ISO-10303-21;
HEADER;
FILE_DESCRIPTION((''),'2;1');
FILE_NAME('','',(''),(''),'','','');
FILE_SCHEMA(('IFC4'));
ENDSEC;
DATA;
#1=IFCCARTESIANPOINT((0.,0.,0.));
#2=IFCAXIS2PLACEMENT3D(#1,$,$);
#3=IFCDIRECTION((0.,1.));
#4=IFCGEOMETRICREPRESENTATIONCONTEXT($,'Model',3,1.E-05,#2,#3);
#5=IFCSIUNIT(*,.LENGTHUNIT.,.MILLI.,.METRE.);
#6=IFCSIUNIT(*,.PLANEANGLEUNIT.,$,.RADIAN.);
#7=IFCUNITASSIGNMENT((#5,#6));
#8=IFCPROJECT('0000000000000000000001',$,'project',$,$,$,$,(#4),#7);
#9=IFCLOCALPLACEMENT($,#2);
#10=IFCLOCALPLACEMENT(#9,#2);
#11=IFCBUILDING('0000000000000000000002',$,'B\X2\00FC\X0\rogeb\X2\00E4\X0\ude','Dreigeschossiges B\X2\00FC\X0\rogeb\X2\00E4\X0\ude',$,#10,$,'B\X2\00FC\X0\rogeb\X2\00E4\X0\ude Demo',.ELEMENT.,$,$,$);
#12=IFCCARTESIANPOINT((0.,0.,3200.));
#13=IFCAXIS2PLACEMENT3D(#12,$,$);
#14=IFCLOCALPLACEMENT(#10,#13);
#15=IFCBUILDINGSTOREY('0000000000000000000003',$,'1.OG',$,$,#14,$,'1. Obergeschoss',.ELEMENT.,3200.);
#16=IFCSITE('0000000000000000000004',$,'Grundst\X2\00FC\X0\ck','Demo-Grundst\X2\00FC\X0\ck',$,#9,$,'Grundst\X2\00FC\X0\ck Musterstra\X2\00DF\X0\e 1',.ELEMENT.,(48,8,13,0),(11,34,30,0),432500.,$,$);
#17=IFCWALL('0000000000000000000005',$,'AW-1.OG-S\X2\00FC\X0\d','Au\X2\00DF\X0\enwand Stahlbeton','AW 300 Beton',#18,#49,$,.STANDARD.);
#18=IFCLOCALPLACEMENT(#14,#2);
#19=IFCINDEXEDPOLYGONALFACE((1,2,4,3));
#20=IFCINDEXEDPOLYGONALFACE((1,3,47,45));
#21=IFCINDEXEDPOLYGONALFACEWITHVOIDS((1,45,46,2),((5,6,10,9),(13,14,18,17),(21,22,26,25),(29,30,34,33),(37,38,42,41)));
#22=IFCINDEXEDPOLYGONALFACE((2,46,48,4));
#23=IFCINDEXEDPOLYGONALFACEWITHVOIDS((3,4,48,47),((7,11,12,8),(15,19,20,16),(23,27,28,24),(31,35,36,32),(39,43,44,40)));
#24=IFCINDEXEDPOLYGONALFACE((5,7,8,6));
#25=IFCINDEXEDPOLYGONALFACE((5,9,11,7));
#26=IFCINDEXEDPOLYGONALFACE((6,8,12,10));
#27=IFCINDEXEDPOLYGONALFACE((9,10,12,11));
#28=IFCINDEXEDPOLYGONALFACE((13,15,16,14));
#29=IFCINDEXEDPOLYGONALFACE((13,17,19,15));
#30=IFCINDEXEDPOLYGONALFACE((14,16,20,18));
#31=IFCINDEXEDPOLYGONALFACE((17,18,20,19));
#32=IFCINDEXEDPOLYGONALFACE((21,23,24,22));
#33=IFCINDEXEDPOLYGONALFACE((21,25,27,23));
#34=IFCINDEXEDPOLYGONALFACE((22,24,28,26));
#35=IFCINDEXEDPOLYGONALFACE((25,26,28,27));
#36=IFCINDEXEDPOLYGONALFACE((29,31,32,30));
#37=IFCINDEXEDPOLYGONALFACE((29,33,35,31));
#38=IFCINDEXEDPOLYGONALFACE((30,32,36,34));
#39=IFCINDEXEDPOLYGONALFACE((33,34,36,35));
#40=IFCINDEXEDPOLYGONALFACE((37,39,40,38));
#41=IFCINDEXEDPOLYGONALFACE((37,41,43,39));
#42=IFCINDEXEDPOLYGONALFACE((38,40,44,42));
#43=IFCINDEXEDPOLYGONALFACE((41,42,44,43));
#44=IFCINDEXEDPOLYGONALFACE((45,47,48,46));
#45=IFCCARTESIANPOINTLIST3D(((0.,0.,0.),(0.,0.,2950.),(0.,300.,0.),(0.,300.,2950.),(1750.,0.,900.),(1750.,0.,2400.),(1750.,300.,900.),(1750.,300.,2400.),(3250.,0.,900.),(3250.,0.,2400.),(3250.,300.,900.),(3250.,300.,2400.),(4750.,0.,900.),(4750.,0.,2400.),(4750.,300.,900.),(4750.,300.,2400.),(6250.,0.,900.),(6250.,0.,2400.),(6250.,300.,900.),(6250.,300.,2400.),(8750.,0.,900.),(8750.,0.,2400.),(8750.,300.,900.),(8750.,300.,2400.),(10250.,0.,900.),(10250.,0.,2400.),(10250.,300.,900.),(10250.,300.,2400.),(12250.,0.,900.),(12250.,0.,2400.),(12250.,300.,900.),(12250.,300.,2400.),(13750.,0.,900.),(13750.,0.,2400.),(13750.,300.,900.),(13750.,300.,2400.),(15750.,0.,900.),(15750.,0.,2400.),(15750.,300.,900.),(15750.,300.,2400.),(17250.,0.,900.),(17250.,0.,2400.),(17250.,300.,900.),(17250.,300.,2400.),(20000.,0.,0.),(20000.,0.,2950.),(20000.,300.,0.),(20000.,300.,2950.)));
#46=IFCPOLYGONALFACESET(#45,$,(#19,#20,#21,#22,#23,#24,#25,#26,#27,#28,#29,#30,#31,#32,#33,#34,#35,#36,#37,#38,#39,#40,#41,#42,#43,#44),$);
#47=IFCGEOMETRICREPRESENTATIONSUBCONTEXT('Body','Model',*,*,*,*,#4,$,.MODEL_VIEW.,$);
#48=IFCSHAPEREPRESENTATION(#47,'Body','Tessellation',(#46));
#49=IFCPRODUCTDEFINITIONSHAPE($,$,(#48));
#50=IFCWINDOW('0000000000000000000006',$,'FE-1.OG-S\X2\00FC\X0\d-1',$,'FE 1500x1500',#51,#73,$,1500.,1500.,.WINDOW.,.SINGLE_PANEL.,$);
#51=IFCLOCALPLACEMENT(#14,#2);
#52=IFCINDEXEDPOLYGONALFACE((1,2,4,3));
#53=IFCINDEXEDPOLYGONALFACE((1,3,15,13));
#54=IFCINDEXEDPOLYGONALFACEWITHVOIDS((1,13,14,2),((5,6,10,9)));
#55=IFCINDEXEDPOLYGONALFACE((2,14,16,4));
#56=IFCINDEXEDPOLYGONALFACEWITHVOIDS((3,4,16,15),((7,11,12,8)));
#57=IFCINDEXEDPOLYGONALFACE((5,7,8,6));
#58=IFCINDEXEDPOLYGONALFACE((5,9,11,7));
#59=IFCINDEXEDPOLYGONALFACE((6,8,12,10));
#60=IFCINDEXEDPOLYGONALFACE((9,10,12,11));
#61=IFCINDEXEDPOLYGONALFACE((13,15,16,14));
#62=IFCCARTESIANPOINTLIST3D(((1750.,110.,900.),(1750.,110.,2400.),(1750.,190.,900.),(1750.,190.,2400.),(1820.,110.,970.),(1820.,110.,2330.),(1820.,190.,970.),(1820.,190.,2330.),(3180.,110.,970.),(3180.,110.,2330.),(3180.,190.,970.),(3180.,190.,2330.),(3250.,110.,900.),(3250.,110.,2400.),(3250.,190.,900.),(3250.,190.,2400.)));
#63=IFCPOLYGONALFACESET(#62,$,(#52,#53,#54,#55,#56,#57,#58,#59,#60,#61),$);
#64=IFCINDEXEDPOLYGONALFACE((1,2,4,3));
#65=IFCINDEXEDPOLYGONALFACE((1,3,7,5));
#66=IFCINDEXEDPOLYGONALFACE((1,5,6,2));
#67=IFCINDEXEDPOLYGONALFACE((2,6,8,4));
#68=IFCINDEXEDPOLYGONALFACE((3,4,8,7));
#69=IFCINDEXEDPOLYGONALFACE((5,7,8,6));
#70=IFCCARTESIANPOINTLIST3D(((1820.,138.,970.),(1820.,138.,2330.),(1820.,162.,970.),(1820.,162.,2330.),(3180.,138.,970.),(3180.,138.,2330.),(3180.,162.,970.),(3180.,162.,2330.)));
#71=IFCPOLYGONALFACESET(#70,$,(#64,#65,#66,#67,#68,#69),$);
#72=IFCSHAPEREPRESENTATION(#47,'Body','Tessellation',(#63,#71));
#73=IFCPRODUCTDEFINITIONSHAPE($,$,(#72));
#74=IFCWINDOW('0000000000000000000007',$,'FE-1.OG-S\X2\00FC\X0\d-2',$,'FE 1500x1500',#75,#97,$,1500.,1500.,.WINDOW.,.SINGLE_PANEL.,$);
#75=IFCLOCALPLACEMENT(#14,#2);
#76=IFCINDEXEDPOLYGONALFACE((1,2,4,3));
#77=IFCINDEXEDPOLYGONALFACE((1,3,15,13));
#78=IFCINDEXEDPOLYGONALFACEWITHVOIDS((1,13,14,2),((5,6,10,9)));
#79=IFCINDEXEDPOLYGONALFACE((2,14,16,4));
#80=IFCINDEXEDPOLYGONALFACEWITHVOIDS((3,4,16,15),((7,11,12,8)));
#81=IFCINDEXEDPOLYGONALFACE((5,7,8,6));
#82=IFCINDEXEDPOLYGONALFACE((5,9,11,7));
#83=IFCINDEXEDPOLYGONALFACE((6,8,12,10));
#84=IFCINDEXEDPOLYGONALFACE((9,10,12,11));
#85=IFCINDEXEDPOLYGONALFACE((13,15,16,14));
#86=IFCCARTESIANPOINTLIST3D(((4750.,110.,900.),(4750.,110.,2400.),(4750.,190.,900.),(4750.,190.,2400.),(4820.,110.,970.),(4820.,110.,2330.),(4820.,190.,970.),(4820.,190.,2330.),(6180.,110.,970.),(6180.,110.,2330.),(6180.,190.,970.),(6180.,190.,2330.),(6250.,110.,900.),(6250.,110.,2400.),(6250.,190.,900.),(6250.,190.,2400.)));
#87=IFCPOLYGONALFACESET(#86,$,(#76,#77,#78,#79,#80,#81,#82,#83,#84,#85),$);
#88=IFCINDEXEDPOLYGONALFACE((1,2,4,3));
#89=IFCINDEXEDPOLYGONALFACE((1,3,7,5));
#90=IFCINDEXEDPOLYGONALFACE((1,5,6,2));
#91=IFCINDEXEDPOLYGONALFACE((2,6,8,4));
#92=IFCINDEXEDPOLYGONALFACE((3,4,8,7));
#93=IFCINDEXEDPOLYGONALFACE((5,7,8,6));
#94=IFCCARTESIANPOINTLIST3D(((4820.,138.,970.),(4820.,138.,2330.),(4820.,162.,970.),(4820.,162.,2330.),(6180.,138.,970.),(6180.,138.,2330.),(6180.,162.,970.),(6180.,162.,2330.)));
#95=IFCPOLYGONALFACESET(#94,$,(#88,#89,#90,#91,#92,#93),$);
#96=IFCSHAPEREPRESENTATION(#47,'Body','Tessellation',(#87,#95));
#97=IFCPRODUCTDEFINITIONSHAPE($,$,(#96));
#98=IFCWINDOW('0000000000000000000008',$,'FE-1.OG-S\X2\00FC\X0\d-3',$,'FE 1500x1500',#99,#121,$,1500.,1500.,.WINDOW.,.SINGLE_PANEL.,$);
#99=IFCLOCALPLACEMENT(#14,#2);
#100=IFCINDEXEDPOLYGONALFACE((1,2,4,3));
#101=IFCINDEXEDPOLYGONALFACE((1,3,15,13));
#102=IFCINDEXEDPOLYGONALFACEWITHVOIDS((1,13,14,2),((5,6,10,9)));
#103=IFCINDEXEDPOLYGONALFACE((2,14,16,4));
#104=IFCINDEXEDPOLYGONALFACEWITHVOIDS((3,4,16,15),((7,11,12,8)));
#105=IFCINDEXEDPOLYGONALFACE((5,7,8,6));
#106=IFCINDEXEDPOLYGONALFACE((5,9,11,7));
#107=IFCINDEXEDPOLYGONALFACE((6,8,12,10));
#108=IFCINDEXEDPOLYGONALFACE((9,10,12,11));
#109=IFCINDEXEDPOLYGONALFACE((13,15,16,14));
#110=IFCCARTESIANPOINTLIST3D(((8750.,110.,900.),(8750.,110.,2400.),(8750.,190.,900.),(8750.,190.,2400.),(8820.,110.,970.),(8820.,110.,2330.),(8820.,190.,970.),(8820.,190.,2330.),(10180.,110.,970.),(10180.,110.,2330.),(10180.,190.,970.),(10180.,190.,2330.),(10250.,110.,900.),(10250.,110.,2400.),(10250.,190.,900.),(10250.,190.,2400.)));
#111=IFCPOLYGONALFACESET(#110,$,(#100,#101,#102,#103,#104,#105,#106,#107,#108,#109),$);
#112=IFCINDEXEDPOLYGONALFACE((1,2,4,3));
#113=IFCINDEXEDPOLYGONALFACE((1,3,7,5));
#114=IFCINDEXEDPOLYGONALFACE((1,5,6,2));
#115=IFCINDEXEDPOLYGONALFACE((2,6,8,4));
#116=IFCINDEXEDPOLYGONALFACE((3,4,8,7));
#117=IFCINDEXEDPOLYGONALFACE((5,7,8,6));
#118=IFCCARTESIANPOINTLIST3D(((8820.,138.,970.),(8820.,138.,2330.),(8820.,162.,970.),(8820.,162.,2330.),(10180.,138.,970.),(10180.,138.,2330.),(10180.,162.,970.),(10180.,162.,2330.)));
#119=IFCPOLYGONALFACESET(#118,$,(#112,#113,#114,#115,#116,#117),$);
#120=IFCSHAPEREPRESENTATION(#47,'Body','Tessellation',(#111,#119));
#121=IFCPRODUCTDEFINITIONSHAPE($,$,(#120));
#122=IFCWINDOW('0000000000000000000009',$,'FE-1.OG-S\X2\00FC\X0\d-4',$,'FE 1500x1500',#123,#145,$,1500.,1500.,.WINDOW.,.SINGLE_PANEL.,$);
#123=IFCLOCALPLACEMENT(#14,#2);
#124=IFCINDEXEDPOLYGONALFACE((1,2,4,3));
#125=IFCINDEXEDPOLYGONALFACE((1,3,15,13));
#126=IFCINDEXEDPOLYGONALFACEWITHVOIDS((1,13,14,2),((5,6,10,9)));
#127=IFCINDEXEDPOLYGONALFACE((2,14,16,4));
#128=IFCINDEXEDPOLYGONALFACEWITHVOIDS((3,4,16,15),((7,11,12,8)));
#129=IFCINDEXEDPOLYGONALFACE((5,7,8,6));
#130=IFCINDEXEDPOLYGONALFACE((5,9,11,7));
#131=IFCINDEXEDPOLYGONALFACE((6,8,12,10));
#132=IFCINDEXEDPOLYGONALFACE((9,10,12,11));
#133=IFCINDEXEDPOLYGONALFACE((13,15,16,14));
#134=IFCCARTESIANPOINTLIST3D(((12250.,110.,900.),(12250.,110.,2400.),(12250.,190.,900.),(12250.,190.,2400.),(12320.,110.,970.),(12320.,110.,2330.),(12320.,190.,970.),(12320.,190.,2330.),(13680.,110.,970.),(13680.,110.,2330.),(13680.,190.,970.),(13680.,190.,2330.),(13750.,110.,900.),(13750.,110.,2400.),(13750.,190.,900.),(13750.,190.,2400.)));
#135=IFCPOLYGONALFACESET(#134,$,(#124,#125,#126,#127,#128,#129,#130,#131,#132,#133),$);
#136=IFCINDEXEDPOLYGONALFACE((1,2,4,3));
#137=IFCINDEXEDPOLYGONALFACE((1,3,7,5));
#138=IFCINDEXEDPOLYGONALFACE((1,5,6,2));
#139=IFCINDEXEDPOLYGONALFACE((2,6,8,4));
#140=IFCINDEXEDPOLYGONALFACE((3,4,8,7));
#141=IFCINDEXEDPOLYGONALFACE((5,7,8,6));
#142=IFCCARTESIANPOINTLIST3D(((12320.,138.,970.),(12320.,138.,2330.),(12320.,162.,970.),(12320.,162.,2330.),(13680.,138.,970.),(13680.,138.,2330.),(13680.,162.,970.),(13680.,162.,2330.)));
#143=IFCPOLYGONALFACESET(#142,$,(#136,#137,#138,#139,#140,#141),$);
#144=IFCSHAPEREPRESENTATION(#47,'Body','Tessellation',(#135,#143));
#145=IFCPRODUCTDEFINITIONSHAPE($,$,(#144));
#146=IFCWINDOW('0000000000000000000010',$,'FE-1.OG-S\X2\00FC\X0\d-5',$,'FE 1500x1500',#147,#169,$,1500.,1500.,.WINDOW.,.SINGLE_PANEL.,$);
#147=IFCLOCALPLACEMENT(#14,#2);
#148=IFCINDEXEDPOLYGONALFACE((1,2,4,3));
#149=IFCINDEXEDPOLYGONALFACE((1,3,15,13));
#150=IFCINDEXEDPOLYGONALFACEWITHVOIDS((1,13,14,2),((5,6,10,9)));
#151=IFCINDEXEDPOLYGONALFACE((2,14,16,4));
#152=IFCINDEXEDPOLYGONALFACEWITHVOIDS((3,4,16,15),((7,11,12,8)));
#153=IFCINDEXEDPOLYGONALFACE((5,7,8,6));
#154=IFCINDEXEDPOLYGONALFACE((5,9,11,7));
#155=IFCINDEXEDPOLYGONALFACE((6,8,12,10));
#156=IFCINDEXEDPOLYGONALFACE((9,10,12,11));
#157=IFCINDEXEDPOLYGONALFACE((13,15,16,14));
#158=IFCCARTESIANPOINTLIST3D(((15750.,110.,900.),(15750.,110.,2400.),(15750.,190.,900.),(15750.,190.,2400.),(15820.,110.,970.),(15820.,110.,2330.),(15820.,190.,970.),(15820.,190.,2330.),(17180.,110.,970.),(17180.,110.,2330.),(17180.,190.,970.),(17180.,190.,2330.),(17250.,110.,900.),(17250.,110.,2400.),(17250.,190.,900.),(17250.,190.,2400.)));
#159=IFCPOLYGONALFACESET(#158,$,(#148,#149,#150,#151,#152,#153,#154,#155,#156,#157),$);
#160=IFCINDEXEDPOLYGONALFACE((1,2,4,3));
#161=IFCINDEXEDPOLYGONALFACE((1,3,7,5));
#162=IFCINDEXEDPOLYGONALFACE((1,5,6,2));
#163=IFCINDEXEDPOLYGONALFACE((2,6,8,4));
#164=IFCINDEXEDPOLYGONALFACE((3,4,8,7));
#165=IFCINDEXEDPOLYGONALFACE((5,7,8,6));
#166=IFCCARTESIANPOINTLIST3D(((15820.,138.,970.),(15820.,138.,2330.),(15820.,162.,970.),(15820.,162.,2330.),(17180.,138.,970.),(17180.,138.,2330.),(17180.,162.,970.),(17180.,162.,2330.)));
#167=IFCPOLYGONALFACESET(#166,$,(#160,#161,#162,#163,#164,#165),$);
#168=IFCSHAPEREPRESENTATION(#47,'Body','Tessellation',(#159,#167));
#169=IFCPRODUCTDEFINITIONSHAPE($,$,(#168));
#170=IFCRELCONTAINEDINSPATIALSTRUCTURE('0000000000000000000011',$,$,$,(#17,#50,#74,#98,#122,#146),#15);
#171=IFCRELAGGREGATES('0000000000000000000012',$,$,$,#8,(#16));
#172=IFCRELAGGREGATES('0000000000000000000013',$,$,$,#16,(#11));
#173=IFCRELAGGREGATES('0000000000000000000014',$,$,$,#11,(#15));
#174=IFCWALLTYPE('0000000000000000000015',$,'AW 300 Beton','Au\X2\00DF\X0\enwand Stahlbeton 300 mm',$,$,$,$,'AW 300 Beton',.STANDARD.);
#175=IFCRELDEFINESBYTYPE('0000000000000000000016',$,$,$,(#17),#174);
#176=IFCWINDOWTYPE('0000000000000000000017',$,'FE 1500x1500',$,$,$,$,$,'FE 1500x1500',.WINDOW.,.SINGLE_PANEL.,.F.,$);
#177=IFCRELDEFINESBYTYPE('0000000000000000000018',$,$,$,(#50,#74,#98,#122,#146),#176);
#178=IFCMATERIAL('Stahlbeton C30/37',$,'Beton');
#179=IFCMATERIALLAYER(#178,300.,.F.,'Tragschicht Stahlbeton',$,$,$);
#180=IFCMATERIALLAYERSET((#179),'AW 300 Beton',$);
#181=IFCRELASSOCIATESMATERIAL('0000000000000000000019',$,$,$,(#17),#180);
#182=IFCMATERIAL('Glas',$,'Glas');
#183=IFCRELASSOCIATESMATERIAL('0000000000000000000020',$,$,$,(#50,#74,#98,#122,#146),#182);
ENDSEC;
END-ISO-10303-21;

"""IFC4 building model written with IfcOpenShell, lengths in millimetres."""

from ifc_helpers import new_model, si_unit, direction, frame, frame_2d, origin, origin_2d, place, context, subcontext, project, spatial, polyline, rectangle, outline, extrude, material, layer, layer_set, layer_usage, type_object, element, fill, save


model = new_model("IFC4")

# Units and contexts
model_context = context("Model", 3, precision=1e-05, world=origin(), true_north=direction((0.0, 1.0)))
body_context = subcontext(model_context, "Body", "Model", "MODEL_VIEW")
ifc_project = project(units=[si_unit("LENGTHUNIT", "METRE", prefix="MILLI"), si_unit("PLANEANGLEUNIT", "RADIAN")], contexts=[model_context])

# Site, building, storey
site_placement = place(None, origin())
site = spatial("IfcSite", under=ifc_project, at=site_placement, Name="Grundstück", Description="Demo-Grundstück", LongName="Grundstück Musterstraße 1", CompositionType="ELEMENT", RefLatitude=(48, 8, 13, 0), RefLongitude=(11, 34, 30, 0), RefElevation=432500.0)
building_placement = place(site_placement, origin())
building = spatial("IfcBuilding", under=site, at=building_placement, Name="Bürogebäude", Description="Dreigeschossiges Bürogebäude", LongName="Bürogebäude Demo", CompositionType="ELEMENT")
storey_placement = place(building_placement, frame((0.0, 0.0, 3200.0)))
storey = spatial("IfcBuildingStorey", under=building, at=storey_placement, Name="1.OG", LongName="1. Obergeschoss", CompositionType="ELEMENT", Elevation=3200.0)

# Shared definitions
ifc_material_1 = material(Name="Stahlbeton C30/37", Category="Beton")

# Wall, openings, windows
ifc_layer = layer(ifc_material_1, 300.0, ventilated=False, Name="Tragschicht Stahlbeton")
ifc_layer_set = layer_set([ifc_layer], Name="AW 300 Beton")
ifc_layer_usage = layer_usage(ifc_layer_set, "AXIS2", "POSITIVE", -150.0)
wall_type = type_object("IfcWallType", Name="AW 300 Beton", Description="Außenwand Stahlbeton 300 mm", ElementType="AW 300 Beton", PredefinedType="STANDARD")
wall_1_placement = place(storey_placement, frame((0.0, 150.0, 0.0)))
wall_1 = element("IfcWall", 1, at=wall_1_placement, inside=storey, type_object=wall_type, material=ifc_layer_usage, Name="AW-1.OG-Süd", Description="Außenwand Stahlbeton", ObjectType="AW 300 Beton", PredefinedType="STANDARD", context=body_context, shape_type="SweptSolid", body=[
    extrude(rectangle(XDim=20000.0, YDim=300.0, at=frame_2d((10000.0, 0.0))), origin(), (0.0, 0.0, 1.0), 2950.0),
])
opening_1_placement = place(wall_1_placement, frame((2500.0, 0.0, 900.0)))
opening_1 = element("IfcOpeningElement", 2, at=opening_1_placement, cuts=wall_1, PredefinedType="OPENING", context=body_context, shape_type="SweptSolid", body=[
    extrude(rectangle(XDim=1500.0, YDim=340.0, at=origin_2d()), origin(), (0.0, 0.0, 1.0), 1500.0),
])
opening_2_placement = place(wall_1_placement, frame((5500.0, 0.0, 900.0)))
opening_2 = element("IfcOpeningElement", 3, at=opening_2_placement, cuts=wall_1, PredefinedType="OPENING", context=body_context, shape_type="SweptSolid", body=[
    extrude(rectangle(XDim=1500.0, YDim=340.0, at=origin_2d()), origin(), (0.0, 0.0, 1.0), 1500.0),
])
opening_3_placement = place(wall_1_placement, frame((9500.0, 0.0, 900.0)))
opening_3 = element("IfcOpeningElement", 4, at=opening_3_placement, cuts=wall_1, PredefinedType="OPENING", context=body_context, shape_type="SweptSolid", body=[
    extrude(rectangle(XDim=1500.0, YDim=340.0, at=origin_2d()), origin(), (0.0, 0.0, 1.0), 1500.0),
])
opening_4_placement = place(wall_1_placement, frame((13000.0, 0.0, 900.0)))
opening_4 = element("IfcOpeningElement", 5, at=opening_4_placement, cuts=wall_1, PredefinedType="OPENING", context=body_context, shape_type="SweptSolid", body=[
    extrude(rectangle(XDim=1500.0, YDim=340.0, at=origin_2d()), origin(), (0.0, 0.0, 1.0), 1500.0),
])
opening_5_placement = place(wall_1_placement, frame((16500.0, 0.0, 900.0)))
opening_5 = element("IfcOpeningElement", 6, at=opening_5_placement, cuts=wall_1, PredefinedType="OPENING", context=body_context, shape_type="SweptSolid", body=[
    extrude(rectangle(XDim=1500.0, YDim=340.0, at=origin_2d()), origin(), (0.0, 0.0, 1.0), 1500.0),
])
ifc_material_2 = material(Name="Glas", Category="Glas")
window_type = type_object("IfcWindowType", Name="FE 1500x1500", ElementType="FE 1500x1500", ParameterTakesPrecedence=False, PartitioningType="SINGLE_PANEL", PredefinedType="WINDOW")
window_1_placement = place(opening_1_placement, origin())
window_1 = element("IfcWindow", 7, at=window_1_placement, inside=storey, type_object=window_type, material=ifc_material_2, Name="FE-1.OG-Süd-1", ObjectType="FE 1500x1500", OverallHeight=1500.0, OverallWidth=1500.0, PartitioningType="SINGLE_PANEL", PredefinedType="WINDOW", context=body_context, shape_type="SweptSolid", body=[
    extrude(outline(polyline([(-750.0, 0.0), (750.0, 0.0), (750.0, 1500.0), (-750.0, 1500.0), (-750.0, 0.0)]), holes=[polyline([(-680.0, 70.0), (680.0, 70.0), (680.0, 1430.0), (-680.0, 1430.0), (-680.0, 70.0)])]), frame((0.0, 40.0, 0.0), z_axis=(0.0, -1.0, 0.0), x_axis=(1.0, 0.0, 0.0)), (0.0, 0.0, 1.0), 80.0),
    extrude(rectangle(XDim=1360.0, YDim=24.0, at=origin_2d()), frame((0.0, 0.0, 70.0)), (0.0, 0.0, 1.0), 1360.0),
])
fill(opening_1, window_1)
window_2_placement = place(opening_2_placement, origin())
window_2 = element("IfcWindow", 8, at=window_2_placement, inside=storey, type_object=window_type, material=ifc_material_2, Name="FE-1.OG-Süd-2", ObjectType="FE 1500x1500", OverallHeight=1500.0, OverallWidth=1500.0, PartitioningType="SINGLE_PANEL", PredefinedType="WINDOW", context=body_context, shape_type="SweptSolid", body=[
    extrude(outline(polyline([(-750.0, 0.0), (750.0, 0.0), (750.0, 1500.0), (-750.0, 1500.0), (-750.0, 0.0)]), holes=[polyline([(-680.0, 70.0), (680.0, 70.0), (680.0, 1430.0), (-680.0, 1430.0), (-680.0, 70.0)])]), frame((0.0, 40.0, 0.0), z_axis=(0.0, -1.0, 0.0), x_axis=(1.0, 0.0, 0.0)), (0.0, 0.0, 1.0), 80.0),
    extrude(rectangle(XDim=1360.0, YDim=24.0, at=origin_2d()), frame((0.0, 0.0, 70.0)), (0.0, 0.0, 1.0), 1360.0),
])
fill(opening_2, window_2)
window_3_placement = place(opening_3_placement, origin())
window_3 = element("IfcWindow", 9, at=window_3_placement, inside=storey, type_object=window_type, material=ifc_material_2, Name="FE-1.OG-Süd-3", ObjectType="FE 1500x1500", OverallHeight=1500.0, OverallWidth=1500.0, PartitioningType="SINGLE_PANEL", PredefinedType="WINDOW", context=body_context, shape_type="SweptSolid", body=[
    extrude(outline(polyline([(-750.0, 0.0), (750.0, 0.0), (750.0, 1500.0), (-750.0, 1500.0), (-750.0, 0.0)]), holes=[polyline([(-680.0, 70.0), (680.0, 70.0), (680.0, 1430.0), (-680.0, 1430.0), (-680.0, 70.0)])]), frame((0.0, 40.0, 0.0), z_axis=(0.0, -1.0, 0.0), x_axis=(1.0, 0.0, 0.0)), (0.0, 0.0, 1.0), 80.0),
    extrude(rectangle(XDim=1360.0, YDim=24.0, at=origin_2d()), frame((0.0, 0.0, 70.0)), (0.0, 0.0, 1.0), 1360.0),
])
fill(opening_3, window_3)
window_4_placement = place(opening_4_placement, origin())
window_4 = element("IfcWindow", 10, at=window_4_placement, inside=storey, type_object=window_type, material=ifc_material_2, Name="FE-1.OG-Süd-4", ObjectType="FE 1500x1500", OverallHeight=1500.0, OverallWidth=1500.0, PartitioningType="SINGLE_PANEL", PredefinedType="WINDOW", context=body_context, shape_type="SweptSolid", body=[
    extrude(outline(polyline([(-750.0, 0.0), (750.0, 0.0), (750.0, 1500.0), (-750.0, 1500.0), (-750.0, 0.0)]), holes=[polyline([(-680.0, 70.0), (680.0, 70.0), (680.0, 1430.0), (-680.0, 1430.0), (-680.0, 70.0)])]), frame((0.0, 40.0, 0.0), z_axis=(0.0, -1.0, 0.0), x_axis=(1.0, 0.0, 0.0)), (0.0, 0.0, 1.0), 80.0),
    extrude(rectangle(XDim=1360.0, YDim=24.0, at=origin_2d()), frame((0.0, 0.0, 70.0)), (0.0, 0.0, 1.0), 1360.0),
])
fill(opening_4, window_4)
window_5_placement = place(opening_5_placement, origin())
window_5 = element("IfcWindow", 11, at=window_5_placement, inside=storey, type_object=window_type, material=ifc_material_2, Name="FE-1.OG-Süd-5", ObjectType="FE 1500x1500", OverallHeight=1500.0, OverallWidth=1500.0, PartitioningType="SINGLE_PANEL", PredefinedType="WINDOW", context=body_context, shape_type="SweptSolid", body=[
    extrude(outline(polyline([(-750.0, 0.0), (750.0, 0.0), (750.0, 1500.0), (-750.0, 1500.0), (-750.0, 0.0)]), holes=[polyline([(-680.0, 70.0), (680.0, 70.0), (680.0, 1430.0), (-680.0, 1430.0), (-680.0, 70.0)])]), frame((0.0, 40.0, 0.0), z_axis=(0.0, -1.0, 0.0), x_axis=(1.0, 0.0, 0.0)), (0.0, 0.0, 1.0), 80.0),
    extrude(rectangle(XDim=1360.0, YDim=24.0, at=origin_2d()), frame((0.0, 0.0, 70.0)), (0.0, 0.0, 1.0), 1360.0),
])
fill(opening_5, window_5)

save(model, "model.ifc")
